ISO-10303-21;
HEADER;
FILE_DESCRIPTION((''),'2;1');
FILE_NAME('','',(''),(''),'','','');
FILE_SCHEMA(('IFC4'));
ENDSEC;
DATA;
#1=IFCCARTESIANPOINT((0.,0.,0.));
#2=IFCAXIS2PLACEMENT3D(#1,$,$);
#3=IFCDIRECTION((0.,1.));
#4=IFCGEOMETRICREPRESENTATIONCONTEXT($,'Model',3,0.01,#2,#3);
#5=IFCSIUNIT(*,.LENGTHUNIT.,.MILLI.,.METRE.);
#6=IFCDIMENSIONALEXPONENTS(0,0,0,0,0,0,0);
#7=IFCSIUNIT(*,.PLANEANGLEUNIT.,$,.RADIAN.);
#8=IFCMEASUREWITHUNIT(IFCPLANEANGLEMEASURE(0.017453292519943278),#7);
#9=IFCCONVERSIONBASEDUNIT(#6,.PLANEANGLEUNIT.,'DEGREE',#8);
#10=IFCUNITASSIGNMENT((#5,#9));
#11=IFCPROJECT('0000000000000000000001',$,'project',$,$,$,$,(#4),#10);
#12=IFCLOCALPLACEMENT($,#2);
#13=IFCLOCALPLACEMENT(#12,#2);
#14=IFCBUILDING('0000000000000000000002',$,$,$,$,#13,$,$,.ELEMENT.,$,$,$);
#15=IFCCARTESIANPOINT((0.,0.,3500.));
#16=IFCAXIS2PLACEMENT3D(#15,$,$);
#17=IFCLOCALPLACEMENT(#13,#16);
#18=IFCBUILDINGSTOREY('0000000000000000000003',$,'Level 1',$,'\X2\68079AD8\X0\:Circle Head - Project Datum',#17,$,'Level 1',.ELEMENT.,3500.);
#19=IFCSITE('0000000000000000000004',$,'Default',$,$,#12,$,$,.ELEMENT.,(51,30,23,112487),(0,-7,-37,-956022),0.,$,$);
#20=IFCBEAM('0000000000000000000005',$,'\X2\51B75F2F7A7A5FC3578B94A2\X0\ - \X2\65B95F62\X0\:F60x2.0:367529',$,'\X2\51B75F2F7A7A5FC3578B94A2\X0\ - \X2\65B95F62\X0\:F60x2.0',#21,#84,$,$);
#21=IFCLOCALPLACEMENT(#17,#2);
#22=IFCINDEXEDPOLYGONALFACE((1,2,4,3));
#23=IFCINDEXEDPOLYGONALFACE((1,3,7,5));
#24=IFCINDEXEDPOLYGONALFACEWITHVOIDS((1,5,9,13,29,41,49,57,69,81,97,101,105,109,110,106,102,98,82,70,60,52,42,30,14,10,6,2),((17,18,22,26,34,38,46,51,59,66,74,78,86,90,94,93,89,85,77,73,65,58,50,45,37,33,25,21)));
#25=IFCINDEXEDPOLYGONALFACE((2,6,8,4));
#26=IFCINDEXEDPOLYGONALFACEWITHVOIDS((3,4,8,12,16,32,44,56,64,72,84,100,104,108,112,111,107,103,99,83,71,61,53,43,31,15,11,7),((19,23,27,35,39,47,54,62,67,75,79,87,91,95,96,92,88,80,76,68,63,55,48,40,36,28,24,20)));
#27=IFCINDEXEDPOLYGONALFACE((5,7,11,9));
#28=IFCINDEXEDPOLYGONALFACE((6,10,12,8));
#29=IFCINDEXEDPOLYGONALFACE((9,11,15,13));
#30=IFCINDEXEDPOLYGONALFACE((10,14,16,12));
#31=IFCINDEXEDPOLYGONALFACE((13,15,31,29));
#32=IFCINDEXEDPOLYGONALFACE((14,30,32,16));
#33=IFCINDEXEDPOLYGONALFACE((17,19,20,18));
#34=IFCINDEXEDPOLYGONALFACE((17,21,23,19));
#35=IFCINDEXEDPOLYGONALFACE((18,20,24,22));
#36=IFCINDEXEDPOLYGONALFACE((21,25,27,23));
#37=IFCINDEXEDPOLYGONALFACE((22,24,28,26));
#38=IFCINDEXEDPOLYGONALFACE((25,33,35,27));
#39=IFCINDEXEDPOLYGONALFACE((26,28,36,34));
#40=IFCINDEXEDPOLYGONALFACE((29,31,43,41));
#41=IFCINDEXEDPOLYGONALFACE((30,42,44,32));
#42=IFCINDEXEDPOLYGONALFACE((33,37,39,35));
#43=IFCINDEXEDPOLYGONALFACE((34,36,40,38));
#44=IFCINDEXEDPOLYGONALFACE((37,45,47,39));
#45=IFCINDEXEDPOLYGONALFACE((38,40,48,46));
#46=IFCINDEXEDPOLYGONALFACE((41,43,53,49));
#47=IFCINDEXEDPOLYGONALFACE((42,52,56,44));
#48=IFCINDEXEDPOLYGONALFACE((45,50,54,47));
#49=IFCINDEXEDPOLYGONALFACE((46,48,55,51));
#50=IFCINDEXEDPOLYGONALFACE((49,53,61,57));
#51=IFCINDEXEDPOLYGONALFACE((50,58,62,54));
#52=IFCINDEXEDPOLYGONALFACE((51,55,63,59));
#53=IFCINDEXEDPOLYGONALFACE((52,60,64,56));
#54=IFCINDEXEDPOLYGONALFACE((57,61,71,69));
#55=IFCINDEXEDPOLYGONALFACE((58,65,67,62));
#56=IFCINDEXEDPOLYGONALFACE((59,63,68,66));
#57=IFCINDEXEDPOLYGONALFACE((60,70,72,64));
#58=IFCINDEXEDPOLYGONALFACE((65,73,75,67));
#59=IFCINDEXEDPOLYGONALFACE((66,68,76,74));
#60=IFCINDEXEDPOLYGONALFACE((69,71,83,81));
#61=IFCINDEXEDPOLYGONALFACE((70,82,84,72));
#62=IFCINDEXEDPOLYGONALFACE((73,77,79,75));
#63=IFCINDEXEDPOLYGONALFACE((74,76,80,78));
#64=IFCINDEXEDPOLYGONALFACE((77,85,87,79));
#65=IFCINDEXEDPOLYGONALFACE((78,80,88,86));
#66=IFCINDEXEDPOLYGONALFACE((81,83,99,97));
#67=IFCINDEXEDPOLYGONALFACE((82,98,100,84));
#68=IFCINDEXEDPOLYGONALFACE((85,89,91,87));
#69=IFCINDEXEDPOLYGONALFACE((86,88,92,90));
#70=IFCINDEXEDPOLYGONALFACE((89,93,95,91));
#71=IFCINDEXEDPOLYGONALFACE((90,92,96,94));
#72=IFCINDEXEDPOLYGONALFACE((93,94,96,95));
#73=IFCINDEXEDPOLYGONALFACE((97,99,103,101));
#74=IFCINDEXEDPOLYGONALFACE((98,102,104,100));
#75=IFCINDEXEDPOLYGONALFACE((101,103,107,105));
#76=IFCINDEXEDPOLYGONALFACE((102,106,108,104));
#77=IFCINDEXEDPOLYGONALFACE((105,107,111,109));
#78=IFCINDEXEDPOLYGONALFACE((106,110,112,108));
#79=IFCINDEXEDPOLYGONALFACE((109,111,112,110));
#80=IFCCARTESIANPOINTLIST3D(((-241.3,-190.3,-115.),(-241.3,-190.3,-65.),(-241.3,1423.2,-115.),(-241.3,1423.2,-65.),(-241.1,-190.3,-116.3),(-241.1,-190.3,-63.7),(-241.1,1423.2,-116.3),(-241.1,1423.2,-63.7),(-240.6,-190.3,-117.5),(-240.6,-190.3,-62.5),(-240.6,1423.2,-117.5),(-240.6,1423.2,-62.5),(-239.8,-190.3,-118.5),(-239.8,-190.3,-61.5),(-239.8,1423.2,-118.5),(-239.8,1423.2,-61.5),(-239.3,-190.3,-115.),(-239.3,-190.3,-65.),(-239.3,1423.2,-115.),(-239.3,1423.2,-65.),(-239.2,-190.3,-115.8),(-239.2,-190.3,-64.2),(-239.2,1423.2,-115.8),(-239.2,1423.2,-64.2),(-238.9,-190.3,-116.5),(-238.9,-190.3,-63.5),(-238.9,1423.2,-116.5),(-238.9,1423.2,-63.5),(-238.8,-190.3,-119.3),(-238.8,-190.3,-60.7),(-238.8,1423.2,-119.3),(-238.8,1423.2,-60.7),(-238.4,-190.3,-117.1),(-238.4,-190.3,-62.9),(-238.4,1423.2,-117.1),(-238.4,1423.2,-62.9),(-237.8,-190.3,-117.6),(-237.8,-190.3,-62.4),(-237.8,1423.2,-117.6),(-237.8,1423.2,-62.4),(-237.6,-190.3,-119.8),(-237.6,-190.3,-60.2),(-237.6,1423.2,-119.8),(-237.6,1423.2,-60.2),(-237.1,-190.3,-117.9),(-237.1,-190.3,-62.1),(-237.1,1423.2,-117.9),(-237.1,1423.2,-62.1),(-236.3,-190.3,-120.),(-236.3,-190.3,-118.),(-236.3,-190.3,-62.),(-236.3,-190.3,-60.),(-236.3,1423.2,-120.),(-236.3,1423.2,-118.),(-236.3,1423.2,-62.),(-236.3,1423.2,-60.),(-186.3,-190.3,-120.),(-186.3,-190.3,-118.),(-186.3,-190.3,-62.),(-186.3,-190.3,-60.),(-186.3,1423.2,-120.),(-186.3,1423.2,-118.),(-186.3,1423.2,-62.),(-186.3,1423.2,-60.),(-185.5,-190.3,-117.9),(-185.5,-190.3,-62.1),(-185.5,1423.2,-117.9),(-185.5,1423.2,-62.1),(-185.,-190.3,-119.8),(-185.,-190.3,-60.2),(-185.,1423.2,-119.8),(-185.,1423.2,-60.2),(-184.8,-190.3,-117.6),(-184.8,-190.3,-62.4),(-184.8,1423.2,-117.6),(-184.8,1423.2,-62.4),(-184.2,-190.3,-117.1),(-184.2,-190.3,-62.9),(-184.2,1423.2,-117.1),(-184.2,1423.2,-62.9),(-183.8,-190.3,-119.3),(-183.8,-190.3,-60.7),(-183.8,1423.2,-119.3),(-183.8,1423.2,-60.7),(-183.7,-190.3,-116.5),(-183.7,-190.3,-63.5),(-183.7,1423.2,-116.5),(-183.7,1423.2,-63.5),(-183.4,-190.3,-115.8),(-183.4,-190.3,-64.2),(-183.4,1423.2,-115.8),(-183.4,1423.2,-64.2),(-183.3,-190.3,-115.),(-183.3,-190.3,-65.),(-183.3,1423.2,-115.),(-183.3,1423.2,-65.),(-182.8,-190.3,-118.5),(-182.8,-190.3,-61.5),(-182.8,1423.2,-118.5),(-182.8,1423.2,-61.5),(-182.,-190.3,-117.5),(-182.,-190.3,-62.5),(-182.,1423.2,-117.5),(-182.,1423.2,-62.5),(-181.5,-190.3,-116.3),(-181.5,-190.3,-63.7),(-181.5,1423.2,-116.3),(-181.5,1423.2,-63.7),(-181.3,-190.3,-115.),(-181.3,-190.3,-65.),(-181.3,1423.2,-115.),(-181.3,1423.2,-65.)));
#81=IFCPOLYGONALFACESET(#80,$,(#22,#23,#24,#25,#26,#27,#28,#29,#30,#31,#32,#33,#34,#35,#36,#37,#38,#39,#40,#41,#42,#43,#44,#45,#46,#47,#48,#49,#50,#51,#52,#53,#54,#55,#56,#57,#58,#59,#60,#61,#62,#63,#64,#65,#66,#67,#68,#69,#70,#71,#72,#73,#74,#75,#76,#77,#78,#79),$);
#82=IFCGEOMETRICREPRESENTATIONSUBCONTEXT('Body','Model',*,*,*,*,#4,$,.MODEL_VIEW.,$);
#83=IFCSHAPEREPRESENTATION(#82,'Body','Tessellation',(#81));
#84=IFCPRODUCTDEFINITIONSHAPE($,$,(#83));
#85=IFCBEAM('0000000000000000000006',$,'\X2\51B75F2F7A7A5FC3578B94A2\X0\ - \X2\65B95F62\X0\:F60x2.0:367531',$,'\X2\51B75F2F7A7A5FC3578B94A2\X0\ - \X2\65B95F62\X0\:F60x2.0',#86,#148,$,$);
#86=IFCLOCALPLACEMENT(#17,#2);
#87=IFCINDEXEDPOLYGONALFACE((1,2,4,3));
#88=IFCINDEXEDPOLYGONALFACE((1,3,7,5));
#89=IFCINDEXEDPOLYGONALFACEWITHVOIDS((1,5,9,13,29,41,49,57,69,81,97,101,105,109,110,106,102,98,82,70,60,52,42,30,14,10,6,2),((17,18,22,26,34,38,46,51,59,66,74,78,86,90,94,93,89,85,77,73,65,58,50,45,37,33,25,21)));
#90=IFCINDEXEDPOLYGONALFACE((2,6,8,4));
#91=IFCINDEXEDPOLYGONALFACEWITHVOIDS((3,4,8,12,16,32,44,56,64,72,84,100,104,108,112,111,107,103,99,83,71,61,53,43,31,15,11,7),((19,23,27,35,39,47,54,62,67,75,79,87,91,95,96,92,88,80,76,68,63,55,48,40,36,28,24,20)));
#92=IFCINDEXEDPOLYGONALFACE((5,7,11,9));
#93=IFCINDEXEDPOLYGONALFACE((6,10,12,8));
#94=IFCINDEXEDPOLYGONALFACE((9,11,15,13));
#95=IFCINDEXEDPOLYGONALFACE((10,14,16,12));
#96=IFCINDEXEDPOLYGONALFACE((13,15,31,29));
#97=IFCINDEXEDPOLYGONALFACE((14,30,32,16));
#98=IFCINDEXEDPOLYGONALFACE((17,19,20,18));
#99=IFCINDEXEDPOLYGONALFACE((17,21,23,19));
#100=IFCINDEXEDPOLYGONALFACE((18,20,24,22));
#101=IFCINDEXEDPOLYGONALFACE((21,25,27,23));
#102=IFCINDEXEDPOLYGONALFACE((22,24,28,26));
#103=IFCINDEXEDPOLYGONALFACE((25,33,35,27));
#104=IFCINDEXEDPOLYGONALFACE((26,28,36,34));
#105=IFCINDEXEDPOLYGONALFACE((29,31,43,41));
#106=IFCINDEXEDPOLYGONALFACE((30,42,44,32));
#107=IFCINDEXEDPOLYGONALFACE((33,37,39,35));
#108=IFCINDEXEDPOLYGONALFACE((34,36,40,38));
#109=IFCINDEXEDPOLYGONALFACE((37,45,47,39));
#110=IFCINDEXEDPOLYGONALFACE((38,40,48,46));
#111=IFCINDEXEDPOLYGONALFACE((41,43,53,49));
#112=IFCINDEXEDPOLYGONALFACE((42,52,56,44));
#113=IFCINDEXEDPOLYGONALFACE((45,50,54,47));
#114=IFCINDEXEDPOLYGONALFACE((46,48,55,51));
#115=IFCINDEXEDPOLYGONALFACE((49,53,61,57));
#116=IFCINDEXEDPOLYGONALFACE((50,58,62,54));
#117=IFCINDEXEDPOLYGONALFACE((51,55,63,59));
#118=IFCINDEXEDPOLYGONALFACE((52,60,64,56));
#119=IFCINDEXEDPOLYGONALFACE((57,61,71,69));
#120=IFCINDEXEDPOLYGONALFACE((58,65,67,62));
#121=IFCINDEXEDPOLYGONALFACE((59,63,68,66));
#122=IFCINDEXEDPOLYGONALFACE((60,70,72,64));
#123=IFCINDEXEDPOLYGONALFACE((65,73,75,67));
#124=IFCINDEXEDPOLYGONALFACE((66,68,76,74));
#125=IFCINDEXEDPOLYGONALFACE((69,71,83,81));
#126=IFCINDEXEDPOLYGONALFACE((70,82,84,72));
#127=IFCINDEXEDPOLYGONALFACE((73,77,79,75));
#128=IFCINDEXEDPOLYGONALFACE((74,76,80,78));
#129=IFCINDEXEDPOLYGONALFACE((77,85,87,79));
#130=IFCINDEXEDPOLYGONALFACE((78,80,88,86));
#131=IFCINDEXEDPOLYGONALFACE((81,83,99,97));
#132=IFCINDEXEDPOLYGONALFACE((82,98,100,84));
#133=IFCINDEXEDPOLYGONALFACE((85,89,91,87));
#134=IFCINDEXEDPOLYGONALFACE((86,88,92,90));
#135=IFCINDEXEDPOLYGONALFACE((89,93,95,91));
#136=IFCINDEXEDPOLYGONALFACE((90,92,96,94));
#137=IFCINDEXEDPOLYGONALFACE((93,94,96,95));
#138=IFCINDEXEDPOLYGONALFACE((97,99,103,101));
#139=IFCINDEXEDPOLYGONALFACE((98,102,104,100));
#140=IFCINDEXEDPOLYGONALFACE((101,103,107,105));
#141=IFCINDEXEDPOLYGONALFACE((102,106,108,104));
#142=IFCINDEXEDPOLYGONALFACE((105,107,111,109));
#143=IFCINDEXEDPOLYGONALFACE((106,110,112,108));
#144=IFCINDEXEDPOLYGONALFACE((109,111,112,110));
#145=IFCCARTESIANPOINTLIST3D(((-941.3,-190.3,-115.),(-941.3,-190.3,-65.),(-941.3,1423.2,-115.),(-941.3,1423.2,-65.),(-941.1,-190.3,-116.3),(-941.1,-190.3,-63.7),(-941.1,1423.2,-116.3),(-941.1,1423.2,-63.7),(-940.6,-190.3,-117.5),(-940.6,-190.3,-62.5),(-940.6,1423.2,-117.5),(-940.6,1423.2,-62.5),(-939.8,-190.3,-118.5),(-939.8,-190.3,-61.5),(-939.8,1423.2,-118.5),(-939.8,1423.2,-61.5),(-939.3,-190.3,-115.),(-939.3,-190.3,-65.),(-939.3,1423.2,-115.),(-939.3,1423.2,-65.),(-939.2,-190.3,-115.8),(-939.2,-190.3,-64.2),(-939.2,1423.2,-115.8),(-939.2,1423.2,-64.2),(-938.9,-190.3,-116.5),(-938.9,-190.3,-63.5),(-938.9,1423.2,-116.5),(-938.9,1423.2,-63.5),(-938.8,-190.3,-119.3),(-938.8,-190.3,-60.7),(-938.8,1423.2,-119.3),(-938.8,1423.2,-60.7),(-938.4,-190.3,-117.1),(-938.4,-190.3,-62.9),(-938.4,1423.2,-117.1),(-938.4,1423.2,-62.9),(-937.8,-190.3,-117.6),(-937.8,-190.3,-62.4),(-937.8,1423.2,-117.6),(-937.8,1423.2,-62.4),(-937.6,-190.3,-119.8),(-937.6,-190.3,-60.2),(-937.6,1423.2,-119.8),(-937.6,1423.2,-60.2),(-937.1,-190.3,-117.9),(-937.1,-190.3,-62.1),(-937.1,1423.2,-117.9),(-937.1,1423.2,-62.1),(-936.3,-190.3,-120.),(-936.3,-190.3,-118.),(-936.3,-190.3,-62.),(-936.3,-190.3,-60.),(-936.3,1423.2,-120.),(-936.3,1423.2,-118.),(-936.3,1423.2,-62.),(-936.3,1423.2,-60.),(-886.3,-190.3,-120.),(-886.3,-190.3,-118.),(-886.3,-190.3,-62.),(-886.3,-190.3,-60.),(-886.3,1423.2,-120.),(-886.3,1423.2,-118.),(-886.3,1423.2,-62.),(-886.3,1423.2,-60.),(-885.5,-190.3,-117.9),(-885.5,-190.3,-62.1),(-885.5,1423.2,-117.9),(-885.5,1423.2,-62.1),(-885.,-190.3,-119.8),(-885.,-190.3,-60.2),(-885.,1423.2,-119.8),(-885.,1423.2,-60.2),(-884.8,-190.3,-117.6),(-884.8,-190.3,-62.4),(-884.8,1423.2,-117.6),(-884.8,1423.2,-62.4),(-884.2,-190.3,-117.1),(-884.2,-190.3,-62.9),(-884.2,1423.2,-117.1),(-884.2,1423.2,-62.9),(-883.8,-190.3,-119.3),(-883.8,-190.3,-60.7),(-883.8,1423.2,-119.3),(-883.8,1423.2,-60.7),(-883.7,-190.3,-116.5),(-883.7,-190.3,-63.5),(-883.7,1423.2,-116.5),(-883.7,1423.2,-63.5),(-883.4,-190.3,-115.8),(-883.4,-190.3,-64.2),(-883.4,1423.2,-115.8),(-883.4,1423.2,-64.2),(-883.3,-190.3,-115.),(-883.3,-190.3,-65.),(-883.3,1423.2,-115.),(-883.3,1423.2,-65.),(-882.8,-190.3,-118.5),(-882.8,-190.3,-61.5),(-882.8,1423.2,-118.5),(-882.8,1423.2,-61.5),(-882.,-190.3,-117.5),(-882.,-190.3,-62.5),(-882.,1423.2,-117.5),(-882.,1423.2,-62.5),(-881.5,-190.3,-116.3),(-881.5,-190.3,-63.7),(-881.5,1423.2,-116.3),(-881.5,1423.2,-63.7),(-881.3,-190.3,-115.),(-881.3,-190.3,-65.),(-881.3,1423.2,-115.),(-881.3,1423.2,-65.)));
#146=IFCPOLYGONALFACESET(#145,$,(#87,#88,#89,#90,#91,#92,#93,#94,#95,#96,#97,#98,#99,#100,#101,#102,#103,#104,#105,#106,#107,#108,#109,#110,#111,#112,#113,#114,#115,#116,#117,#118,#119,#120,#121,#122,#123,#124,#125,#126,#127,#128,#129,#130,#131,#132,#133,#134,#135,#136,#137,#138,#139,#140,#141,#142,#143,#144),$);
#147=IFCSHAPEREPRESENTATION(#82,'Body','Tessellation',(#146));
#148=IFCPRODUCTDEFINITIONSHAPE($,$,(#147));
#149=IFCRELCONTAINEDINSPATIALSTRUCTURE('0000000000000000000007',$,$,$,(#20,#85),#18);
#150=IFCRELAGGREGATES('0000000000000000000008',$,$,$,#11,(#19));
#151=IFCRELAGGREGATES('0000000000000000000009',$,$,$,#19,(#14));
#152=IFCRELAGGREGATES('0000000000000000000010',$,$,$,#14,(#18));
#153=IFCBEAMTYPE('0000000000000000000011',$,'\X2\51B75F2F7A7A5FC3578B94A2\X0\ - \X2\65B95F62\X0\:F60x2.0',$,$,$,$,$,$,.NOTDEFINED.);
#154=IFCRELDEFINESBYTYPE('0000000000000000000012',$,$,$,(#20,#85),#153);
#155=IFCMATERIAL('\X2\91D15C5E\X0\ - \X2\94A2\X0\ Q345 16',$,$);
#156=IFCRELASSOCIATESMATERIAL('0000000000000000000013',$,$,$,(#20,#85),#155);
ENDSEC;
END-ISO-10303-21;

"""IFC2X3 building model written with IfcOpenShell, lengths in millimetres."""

from ifc_helpers import new_model, entity, si_unit, converted_unit, direction, frame, frame_2d, origin, place, context, subcontext, project, spatial, polyline, circle_curve, parameter, trimmed, segment, composite_curve, outline, extrude, material, type_object, element, save


model = new_model("IFC2X3")

# Units and contexts
model_context = context("Model", 3, precision=0.01, world=origin(), true_north=direction((0.0, 1.0)))
body_context = subcontext(model_context, "Body", "Model", "MODEL_VIEW")
ifc_project = project(units=[si_unit("LENGTHUNIT", "METRE", prefix="MILLI"), converted_unit("PLANEANGLEUNIT", "DEGREE", entity("IfcPlaneAngleMeasure", 0.017453292519943278), si_unit("PLANEANGLEUNIT", "RADIAN"), dimensions=[0, 0, 0, 0, 0, 0, 0])], contexts=[model_context])

# Site, building, storey
site_placement = place(None, origin())
site = spatial("IfcSite", under=ifc_project, at=site_placement, Name="Default", CompositionType="ELEMENT", RefLatitude=(51, 30, 23, 112487), RefLongitude=(0, -7, -37, -956022), RefElevation=0.0)
building_placement = place(site_placement, origin())
building = spatial("IfcBuilding", under=site, at=building_placement, CompositionType="ELEMENT")
storey_placement = place(building_placement, frame((0.0, 0.0, 3500.0)))
storey = spatial("IfcBuildingStorey", under=building, at=storey_placement, Name="Level 1", ObjectType="标高:Circle Head - Project Datum", LongName="Level 1", CompositionType="ELEMENT", Elevation=3500.0)

# Beams
ifc_material_1 = material(Name="金属 - 钢 Q345 16")
beam_type_1 = type_object("IfcBeamType", Name="冷弯空心型钢 - 方形:F60x2.0", PredefinedType="NOTDEFINED")
beam_1_placement = place(storey_placement, frame((-211.3, 1388.1, -60.0), z_axis=(0.0, 0.0, 1.0), x_axis=(0.0, -1.0, 0.0)))
element("IfcBeam", 1, at=beam_1_placement, inside=storey, type_object=beam_type_1, material=ifc_material_1, Name="冷弯空心型钢 - 方形:F60x2.0:367529", ObjectType="冷弯空心型钢 - 方形:F60x2.0", context=body_context, shape_type="SweptSolid", body=[
    extrude(outline(composite_curve([segment(trimmed(circle_curve(frame_2d((-25.0, 25.0), x_axis=(1.0, 0.0)), 5.0), [parameter(90.0)], [parameter(180.0)], True, "PARAMETER"), True, "CONTINUOUS"), segment(polyline([(-30.0, 25.0), (-30.0, -25.0)]), True, "CONTINUOUS"), segment(trimmed(circle_curve(frame_2d((-25.0, -25.0), x_axis=(1.0, 0.0)), 5.0), [parameter(180.0)], [parameter(270.0)], True, "PARAMETER"), True, "CONTINUOUS"), segment(polyline([(-25.0, -30.0), (25.0, -30.0)]), True, "CONTINUOUS"), segment(trimmed(circle_curve(frame_2d((25.0, -25.0), x_axis=(1.0, 0.0)), 5.0), [parameter(270.0)], [parameter(0.0)], True, "PARAMETER"), True, "CONTINUOUS"), segment(polyline([(30.0, -25.0), (30.0, 25.0)]), True, "CONTINUOUS"), segment(trimmed(circle_curve(frame_2d((25.0, 25.0), x_axis=(1.0, 0.0)), 5.0), [parameter(0.0)], [parameter(90.0)], True, "PARAMETER"), True, "CONTINUOUS"), segment(polyline([(25.0, 30.0), (-25.0, 30.0)]), True, "CONTINUOUS")], self_intersect=False), holes=[composite_curve([segment(polyline([(-25.0, 28.0), (25.0, 28.0)]), True, "CONTINUOUS"), segment(trimmed(circle_curve(frame_2d((25.0, 25.0), x_axis=(1.0, 0.0)), 3.0), [parameter(0.0)], [parameter(90.0)], True, "PARAMETER"), False, "CONTINUOUS"), segment(polyline([(28.0, 25.0), (28.0, -25.0)]), True, "CONTINUOUS"), segment(trimmed(circle_curve(frame_2d((25.0, -25.0), x_axis=(1.0, 0.0)), 3.0), [parameter(270.0)], [parameter(360.0)], True, "PARAMETER"), False, "CONTINUOUS"), segment(polyline([(25.0, -28.0), (-25.0, -28.0)]), True, "CONTINUOUS"), segment(trimmed(circle_curve(frame_2d((-25.0, -25.0), x_axis=(1.0, 0.0)), 3.0), [parameter(180.0)], [parameter(270.0)], True, "PARAMETER"), False, "CONTINUOUS"), segment(polyline([(-28.0, -25.0), (-28.0, 25.0)]), True, "CONTINUOUS"), segment(trimmed(circle_curve(frame_2d((-25.0, 25.0), x_axis=(1.0, 0.0)), 3.0), [parameter(90.0)], [parameter(180.0)], True, "PARAMETER"), False, "CONTINUOUS")], self_intersect=False)]), frame((-35.1, 0.0, -30.0), z_axis=(1.0, 0.0, 0.0), x_axis=(0.0, 1.0, 0.0)), (0.0, 0.0, 1.0), 1613.5),
])
beam_2_placement = place(storey_placement, frame((-911.3, 1388.1, -60.0), z_axis=(0.0, 0.0, 1.0), x_axis=(0.0, -1.0, 0.0)))
element("IfcBeam", 2, at=beam_2_placement, inside=storey, type_object=beam_type_1, material=ifc_material_1, Name="冷弯空心型钢 - 方形:F60x2.0:367531", ObjectType="冷弯空心型钢 - 方形:F60x2.0", context=body_context, shape_type="SweptSolid", body=[
    extrude(outline(composite_curve([segment(trimmed(circle_curve(frame_2d((-25.0, 25.0), x_axis=(1.0, 0.0)), 5.0), [parameter(90.0)], [parameter(180.0)], True, "PARAMETER"), True, "CONTINUOUS"), segment(polyline([(-30.0, 25.0), (-30.0, -25.0)]), True, "CONTINUOUS"), segment(trimmed(circle_curve(frame_2d((-25.0, -25.0), x_axis=(1.0, 0.0)), 5.0), [parameter(180.0)], [parameter(270.0)], True, "PARAMETER"), True, "CONTINUOUS"), segment(polyline([(-25.0, -30.0), (25.0, -30.0)]), True, "CONTINUOUS"), segment(trimmed(circle_curve(frame_2d((25.0, -25.0), x_axis=(1.0, 0.0)), 5.0), [parameter(270.0)], [parameter(0.0)], True, "PARAMETER"), True, "CONTINUOUS"), segment(polyline([(30.0, -25.0), (30.0, 25.0)]), True, "CONTINUOUS"), segment(trimmed(circle_curve(frame_2d((25.0, 25.0), x_axis=(1.0, 0.0)), 5.0), [parameter(0.0)], [parameter(90.0)], True, "PARAMETER"), True, "CONTINUOUS"), segment(polyline([(25.0, 30.0), (-25.0, 30.0)]), True, "CONTINUOUS")], self_intersect=False), holes=[composite_curve([segment(polyline([(-25.0, 28.0), (25.0, 28.0)]), True, "CONTINUOUS"), segment(trimmed(circle_curve(frame_2d((25.0, 25.0), x_axis=(1.0, 0.0)), 3.0), [parameter(0.0)], [parameter(90.0)], True, "PARAMETER"), False, "CONTINUOUS"), segment(polyline([(28.0, 25.0), (28.0, -25.0)]), True, "CONTINUOUS"), segment(trimmed(circle_curve(frame_2d((25.0, -25.0), x_axis=(1.0, 0.0)), 3.0), [parameter(270.0)], [parameter(360.0)], True, "PARAMETER"), False, "CONTINUOUS"), segment(polyline([(25.0, -28.0), (-25.0, -28.0)]), True, "CONTINUOUS"), segment(trimmed(circle_curve(frame_2d((-25.0, -25.0), x_axis=(1.0, 0.0)), 3.0), [parameter(180.0)], [parameter(270.0)], True, "PARAMETER"), False, "CONTINUOUS"), segment(polyline([(-28.0, -25.0), (-28.0, 25.0)]), True, "CONTINUOUS"), segment(trimmed(circle_curve(frame_2d((-25.0, 25.0), x_axis=(1.0, 0.0)), 3.0), [parameter(90.0)], [parameter(180.0)], True, "PARAMETER"), False, "CONTINUOUS")], self_intersect=False)]), frame((-35.1, 0.0, -30.0), z_axis=(1.0, 0.0, 0.0), x_axis=(0.0, 1.0, 0.0)), (0.0, 0.0, 1.0), 1613.5),
])

save(model, "model.ifc")
